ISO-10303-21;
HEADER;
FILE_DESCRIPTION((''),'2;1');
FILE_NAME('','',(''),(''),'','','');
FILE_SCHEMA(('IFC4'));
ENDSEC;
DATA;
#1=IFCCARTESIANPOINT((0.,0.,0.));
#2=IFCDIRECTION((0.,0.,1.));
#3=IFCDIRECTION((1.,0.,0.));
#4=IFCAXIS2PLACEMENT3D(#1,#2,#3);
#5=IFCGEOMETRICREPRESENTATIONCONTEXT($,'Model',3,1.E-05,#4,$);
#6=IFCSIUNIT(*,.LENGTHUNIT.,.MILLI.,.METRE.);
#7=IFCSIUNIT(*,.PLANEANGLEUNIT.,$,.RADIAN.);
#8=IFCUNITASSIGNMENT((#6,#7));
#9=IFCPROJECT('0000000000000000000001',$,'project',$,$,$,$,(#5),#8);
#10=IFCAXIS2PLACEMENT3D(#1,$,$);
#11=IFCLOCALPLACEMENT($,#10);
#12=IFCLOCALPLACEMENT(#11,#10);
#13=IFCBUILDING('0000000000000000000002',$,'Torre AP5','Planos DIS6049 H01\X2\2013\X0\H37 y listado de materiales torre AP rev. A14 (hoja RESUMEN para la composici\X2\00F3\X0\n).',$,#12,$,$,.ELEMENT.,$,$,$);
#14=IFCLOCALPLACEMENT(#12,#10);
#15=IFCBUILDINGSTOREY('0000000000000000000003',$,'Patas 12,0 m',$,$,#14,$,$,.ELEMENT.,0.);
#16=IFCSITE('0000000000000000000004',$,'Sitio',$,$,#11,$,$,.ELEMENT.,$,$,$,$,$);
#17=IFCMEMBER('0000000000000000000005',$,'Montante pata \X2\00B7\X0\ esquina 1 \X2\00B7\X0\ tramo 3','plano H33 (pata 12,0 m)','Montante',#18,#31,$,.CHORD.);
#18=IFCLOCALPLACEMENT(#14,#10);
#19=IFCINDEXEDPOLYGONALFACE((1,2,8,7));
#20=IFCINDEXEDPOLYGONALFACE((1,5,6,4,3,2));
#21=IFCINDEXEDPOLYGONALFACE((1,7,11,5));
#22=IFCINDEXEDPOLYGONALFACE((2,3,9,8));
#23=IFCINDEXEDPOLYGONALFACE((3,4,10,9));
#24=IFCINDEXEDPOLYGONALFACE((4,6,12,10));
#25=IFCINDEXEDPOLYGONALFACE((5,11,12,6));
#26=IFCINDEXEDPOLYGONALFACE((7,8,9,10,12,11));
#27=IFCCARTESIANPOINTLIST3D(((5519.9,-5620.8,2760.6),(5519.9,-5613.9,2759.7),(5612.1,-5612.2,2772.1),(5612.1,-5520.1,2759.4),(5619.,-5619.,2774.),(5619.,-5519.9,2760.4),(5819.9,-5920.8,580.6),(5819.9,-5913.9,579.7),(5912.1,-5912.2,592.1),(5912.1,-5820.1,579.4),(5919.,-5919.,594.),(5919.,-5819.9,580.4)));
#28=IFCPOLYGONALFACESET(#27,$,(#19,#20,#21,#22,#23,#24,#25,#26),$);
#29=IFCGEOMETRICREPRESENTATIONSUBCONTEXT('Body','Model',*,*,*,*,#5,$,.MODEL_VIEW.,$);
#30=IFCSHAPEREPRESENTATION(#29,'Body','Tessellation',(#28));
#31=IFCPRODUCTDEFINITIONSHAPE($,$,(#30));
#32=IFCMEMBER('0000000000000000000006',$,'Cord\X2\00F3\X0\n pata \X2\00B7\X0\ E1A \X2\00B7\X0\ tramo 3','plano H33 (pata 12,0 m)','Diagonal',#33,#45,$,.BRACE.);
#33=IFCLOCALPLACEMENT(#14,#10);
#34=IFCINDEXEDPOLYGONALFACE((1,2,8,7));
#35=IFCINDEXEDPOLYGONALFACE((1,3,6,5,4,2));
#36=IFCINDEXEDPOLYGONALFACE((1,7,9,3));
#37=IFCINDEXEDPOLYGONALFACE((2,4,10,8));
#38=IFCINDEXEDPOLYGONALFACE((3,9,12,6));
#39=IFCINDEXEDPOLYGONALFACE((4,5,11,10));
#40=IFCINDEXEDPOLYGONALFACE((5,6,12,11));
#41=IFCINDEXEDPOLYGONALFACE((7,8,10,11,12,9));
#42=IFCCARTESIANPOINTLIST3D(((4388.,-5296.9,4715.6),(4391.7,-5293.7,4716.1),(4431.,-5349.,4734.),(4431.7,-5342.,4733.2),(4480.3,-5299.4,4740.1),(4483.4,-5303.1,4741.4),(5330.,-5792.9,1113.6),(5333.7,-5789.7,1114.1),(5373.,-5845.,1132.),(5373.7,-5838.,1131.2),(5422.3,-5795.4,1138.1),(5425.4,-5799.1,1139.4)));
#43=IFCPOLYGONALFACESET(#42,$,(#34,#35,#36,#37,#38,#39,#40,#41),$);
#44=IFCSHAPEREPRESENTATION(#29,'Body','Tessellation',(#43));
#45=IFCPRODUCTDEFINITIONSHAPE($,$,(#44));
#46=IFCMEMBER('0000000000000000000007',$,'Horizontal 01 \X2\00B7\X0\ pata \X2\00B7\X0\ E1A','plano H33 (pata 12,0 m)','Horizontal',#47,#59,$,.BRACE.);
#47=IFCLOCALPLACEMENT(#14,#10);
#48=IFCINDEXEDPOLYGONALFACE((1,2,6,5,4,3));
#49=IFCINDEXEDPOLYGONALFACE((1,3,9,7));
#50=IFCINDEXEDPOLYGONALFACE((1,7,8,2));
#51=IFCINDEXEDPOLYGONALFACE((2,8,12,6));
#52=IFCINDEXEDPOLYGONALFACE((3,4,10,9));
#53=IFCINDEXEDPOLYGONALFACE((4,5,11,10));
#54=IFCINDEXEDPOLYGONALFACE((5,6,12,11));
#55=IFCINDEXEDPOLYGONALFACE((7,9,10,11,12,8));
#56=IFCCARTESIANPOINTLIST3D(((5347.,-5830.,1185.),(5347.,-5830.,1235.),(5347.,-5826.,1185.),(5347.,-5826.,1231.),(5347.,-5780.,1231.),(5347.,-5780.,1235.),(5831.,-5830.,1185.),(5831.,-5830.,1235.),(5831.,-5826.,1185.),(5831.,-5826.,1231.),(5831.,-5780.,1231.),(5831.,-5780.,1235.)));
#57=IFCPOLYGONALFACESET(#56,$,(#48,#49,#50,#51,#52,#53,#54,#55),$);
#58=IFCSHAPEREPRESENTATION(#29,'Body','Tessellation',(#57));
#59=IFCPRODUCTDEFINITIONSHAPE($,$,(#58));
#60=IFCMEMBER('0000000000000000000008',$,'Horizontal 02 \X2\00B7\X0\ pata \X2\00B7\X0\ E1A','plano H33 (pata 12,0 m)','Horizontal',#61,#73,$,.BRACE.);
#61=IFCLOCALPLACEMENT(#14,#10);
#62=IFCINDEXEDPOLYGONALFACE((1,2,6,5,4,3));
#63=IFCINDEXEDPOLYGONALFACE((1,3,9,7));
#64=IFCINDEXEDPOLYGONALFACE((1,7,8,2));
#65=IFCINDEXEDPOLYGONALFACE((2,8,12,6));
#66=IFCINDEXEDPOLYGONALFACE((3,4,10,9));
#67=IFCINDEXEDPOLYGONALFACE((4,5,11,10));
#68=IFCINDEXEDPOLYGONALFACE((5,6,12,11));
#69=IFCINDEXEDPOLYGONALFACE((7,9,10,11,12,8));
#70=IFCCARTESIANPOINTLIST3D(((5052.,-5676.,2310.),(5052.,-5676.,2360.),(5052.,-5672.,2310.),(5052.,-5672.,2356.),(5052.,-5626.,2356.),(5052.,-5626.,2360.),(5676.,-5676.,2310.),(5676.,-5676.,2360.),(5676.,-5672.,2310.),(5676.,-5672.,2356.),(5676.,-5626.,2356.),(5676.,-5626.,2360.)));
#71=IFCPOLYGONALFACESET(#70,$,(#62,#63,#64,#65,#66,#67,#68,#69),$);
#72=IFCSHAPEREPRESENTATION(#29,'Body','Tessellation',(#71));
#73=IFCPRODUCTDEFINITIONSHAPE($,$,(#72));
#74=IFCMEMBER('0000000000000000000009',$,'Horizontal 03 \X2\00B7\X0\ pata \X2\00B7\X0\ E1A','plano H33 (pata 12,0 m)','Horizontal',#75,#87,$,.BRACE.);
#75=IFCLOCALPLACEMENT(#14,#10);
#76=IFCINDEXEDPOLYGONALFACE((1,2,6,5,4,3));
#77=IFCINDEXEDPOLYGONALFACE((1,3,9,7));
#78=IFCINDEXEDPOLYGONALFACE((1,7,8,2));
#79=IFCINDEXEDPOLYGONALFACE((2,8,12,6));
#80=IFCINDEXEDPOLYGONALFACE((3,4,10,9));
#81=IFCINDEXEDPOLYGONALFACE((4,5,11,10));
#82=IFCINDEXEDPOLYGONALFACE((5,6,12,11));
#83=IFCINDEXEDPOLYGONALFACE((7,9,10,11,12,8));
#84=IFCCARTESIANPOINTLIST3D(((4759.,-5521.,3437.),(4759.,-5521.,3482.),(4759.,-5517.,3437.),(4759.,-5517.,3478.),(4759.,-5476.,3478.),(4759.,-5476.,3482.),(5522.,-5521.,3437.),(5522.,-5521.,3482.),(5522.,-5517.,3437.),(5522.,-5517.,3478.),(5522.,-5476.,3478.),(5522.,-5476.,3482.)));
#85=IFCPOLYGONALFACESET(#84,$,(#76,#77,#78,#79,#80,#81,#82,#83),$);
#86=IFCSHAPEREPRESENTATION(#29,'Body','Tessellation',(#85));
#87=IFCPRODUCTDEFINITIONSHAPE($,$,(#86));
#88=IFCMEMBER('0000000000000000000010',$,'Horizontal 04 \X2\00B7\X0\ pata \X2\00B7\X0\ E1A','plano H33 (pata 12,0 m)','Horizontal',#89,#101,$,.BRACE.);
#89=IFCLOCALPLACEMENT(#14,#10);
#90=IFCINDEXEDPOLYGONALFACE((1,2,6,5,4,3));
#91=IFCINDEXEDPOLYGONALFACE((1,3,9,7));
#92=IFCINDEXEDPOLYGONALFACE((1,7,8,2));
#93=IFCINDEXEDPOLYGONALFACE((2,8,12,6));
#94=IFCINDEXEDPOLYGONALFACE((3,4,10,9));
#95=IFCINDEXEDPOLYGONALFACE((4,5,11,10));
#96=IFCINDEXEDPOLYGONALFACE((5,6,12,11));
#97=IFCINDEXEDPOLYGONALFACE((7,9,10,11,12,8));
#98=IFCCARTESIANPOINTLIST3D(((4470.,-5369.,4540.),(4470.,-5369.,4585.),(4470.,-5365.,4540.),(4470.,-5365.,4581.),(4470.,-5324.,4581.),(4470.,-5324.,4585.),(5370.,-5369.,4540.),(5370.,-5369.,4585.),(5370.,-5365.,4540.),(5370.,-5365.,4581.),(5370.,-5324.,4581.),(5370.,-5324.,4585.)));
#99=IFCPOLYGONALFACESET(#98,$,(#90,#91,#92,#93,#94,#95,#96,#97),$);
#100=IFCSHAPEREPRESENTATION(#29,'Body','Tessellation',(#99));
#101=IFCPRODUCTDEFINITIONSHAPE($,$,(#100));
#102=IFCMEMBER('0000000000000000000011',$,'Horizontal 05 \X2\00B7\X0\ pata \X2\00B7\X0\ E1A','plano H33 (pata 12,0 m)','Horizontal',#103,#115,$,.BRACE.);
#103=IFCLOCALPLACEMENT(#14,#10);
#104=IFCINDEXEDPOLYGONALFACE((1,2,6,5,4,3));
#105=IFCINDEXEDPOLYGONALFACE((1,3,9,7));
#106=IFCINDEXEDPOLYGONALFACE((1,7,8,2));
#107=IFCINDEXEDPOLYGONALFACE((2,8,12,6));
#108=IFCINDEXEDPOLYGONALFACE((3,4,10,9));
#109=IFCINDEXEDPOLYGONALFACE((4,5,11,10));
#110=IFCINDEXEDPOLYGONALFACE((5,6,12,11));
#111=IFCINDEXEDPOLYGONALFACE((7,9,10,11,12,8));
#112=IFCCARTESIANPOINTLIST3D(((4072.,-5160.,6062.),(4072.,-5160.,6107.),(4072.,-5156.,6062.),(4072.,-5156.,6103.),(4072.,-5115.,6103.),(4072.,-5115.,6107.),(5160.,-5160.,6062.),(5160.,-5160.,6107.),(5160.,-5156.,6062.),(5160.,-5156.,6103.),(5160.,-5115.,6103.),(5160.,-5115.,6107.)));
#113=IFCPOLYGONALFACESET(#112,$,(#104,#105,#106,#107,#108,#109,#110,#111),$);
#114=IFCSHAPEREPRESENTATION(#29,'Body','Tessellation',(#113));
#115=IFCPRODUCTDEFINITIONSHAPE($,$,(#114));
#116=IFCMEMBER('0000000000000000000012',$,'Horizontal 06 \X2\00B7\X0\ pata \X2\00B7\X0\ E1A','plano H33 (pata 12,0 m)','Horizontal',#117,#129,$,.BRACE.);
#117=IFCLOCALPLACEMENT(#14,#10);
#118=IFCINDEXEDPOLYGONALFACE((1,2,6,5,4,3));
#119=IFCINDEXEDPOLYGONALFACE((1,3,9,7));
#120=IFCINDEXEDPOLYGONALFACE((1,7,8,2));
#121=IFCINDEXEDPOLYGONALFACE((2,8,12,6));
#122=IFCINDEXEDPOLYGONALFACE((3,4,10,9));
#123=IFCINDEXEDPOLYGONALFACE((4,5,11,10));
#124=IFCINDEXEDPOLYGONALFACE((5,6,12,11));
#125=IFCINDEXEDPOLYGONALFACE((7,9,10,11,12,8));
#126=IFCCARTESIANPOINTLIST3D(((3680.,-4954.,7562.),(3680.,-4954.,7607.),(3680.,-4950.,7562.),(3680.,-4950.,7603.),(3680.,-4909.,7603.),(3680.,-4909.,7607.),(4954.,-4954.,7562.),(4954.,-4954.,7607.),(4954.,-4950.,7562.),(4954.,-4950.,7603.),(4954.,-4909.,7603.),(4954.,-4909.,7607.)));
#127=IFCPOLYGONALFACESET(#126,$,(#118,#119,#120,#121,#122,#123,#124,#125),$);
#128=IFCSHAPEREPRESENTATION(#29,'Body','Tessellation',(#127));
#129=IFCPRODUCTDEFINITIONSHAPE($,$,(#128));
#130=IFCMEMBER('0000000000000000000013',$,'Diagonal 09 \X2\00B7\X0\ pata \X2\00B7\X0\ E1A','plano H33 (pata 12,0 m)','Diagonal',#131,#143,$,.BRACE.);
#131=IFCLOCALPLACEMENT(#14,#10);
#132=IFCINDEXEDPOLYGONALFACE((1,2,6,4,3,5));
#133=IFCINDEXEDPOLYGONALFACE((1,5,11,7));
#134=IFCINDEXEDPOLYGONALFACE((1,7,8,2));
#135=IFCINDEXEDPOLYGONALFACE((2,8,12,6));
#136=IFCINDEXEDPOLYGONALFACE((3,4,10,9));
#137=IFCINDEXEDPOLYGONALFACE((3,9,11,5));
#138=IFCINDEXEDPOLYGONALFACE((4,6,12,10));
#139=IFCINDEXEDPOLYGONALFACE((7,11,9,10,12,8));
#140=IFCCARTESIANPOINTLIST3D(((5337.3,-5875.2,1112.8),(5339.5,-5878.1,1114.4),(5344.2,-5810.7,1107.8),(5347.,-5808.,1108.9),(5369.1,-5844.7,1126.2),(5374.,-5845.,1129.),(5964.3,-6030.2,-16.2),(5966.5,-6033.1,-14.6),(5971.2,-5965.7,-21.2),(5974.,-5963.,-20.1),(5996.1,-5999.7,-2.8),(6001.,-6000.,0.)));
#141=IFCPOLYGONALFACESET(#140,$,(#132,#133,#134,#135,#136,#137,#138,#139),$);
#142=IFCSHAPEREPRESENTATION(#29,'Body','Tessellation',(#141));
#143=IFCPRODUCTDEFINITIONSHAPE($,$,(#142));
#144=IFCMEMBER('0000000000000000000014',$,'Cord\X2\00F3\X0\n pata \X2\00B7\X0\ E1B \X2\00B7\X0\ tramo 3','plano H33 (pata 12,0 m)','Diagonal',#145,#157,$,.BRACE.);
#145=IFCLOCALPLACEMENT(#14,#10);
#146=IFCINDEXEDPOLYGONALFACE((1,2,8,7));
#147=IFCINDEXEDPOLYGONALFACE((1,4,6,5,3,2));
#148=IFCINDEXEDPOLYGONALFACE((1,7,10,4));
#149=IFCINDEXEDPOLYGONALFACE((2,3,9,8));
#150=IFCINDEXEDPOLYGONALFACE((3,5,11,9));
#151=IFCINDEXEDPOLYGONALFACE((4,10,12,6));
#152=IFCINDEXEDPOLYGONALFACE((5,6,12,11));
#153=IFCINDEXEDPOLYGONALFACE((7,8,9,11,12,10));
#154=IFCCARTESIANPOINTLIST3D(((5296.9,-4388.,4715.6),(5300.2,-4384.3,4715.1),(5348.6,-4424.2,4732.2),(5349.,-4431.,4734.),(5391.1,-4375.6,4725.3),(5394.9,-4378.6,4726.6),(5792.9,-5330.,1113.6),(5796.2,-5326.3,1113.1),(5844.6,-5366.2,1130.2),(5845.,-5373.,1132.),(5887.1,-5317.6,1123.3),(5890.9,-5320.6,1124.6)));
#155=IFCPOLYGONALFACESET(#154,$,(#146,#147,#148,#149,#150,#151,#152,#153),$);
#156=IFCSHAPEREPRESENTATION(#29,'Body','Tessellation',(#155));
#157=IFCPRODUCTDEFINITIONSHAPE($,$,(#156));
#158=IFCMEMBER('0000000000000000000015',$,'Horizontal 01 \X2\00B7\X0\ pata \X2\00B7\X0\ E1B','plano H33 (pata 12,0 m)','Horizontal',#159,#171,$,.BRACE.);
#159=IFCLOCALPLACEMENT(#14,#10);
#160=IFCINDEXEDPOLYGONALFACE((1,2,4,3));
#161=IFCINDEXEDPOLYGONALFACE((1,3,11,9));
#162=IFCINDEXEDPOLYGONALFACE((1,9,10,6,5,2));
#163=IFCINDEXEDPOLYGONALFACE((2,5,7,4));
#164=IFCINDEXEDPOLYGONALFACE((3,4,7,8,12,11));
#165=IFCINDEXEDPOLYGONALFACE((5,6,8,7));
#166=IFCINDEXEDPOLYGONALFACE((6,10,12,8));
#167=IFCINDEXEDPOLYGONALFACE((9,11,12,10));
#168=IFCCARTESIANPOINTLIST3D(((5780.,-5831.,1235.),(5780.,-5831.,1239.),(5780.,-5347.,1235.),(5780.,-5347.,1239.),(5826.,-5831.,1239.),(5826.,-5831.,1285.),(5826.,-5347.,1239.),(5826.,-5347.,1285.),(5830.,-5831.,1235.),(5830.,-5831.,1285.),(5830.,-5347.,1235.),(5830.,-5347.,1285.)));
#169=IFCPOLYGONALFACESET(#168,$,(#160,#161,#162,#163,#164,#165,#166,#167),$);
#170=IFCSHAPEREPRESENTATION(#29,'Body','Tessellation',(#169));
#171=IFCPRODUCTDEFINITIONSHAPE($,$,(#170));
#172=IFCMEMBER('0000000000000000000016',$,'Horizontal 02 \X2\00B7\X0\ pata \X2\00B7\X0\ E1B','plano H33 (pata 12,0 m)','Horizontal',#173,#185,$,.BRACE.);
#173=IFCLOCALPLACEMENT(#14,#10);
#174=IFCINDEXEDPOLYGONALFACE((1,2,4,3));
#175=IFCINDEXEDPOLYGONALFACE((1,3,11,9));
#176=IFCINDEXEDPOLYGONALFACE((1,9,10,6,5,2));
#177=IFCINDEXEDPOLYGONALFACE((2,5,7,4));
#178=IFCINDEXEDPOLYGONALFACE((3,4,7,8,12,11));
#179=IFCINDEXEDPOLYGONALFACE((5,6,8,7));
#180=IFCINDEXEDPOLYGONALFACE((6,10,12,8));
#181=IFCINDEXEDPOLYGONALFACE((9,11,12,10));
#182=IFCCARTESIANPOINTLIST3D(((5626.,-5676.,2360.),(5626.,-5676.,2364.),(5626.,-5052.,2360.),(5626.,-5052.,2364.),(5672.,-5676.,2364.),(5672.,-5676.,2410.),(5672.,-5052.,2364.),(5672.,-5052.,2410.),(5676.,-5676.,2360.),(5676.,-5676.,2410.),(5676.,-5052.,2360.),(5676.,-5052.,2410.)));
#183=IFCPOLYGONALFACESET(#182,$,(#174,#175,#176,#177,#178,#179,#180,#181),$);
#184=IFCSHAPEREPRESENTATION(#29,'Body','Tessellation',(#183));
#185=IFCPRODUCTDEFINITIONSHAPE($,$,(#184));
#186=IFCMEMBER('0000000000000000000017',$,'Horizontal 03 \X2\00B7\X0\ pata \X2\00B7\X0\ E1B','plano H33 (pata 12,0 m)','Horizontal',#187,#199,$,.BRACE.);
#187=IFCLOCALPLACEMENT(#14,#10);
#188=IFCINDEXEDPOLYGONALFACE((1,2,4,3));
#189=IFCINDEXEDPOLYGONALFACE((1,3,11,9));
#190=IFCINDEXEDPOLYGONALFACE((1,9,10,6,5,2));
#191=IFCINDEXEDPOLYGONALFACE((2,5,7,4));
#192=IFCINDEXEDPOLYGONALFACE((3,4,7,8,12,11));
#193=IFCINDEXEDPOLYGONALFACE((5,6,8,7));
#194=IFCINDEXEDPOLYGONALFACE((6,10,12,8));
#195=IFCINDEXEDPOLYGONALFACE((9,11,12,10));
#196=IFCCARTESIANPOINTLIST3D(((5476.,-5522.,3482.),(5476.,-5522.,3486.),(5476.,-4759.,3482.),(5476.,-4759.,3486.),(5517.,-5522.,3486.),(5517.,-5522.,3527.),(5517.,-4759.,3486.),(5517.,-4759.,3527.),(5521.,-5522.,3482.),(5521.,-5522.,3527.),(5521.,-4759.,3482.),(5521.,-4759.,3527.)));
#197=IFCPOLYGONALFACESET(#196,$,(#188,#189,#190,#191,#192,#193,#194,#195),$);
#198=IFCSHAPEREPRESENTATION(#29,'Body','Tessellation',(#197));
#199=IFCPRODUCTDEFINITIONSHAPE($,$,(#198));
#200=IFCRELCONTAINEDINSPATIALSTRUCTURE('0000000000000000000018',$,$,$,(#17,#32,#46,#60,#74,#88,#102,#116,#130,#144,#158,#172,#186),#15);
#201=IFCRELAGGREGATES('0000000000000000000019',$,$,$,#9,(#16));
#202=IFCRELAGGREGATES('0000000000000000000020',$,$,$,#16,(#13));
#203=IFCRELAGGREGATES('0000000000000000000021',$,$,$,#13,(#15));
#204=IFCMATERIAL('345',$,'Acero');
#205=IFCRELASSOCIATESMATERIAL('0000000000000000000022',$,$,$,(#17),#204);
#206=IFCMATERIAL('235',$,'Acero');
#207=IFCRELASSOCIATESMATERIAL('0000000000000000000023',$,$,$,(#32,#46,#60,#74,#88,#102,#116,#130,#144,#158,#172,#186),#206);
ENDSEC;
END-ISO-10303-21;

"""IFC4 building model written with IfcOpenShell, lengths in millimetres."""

from ifc_helpers import new_model, si_unit, frame, frame_2d, origin, origin_with_axes, place, context, subcontext, project, spatial, l_section, extrude, material, element, save


model = new_model("IFC4")

# Units and contexts
model_context = context("Model", 3, precision=1e-05, world=origin_with_axes())
body_context = subcontext(model_context, "Body", "Model", "MODEL_VIEW")
ifc_project = project(units=[si_unit("LENGTHUNIT", "METRE", prefix="MILLI"), si_unit("PLANEANGLEUNIT", "RADIAN")], contexts=[model_context])

# Site, building, storey
site_placement = place(None, origin())
site = spatial("IfcSite", under=ifc_project, at=site_placement, Name="Sitio", CompositionType="ELEMENT")
building_placement = place(site_placement, origin())
building = spatial("IfcBuilding", under=site, at=building_placement, Name="Torre AP5", Description="Planos DIS6049 H01–H37 y listado de materiales torre AP rev. A14 (hoja RESUMEN para la composición).", CompositionType="ELEMENT")
storey_placement = place(building_placement, origin())
storey = spatial("IfcBuildingStorey", under=building, at=storey_placement, Name="Patas 12,0 m", CompositionType="ELEMENT", Elevation=0.0)

# Members
ifc_material_1 = material(Name="345", Category="Acero")
member_1_placement = place(storey_placement, frame((5619.0, -5619.0, 2774.0), z_axis=(0.13508, -0.13508, -0.981584), x_axis=(-0.990835, -0.018415, -0.133819)))
element("IfcMember", 1, at=member_1_placement, inside=storey, material=ifc_material_1, Name="Montante pata · esquina 1 · tramo 3", Description="plano H33 (pata 12,0 m)", ObjectType="Montante", PredefinedType="CHORD", context=body_context, shape_type="SweptSolid", body=[
    extrude(l_section(Depth=100.0, Width=100.0, Thickness=7.0, at=frame_2d((50.0, 50.0))), None, (0.0, 0.0, 1.0), 2220.9),
])
ifc_material_2 = material(Name="235", Category="Acero")
member_2_placement = place(storey_placement, frame((4431.0, -5349.0, 4734.0), z_axis=(0.250797, -0.132054, -0.958991), x_axis=(-0.614396, 0.743837, -0.263105)))
element("IfcMember", 2, at=member_2_placement, inside=storey, material=ifc_material_2, Name="Cordón pata · E1A · tramo 3", Description="plano H33 (pata 12,0 m)", ObjectType="Diagonal", PredefinedType="BRACE", context=body_context, shape_type="SweptSolid", body=[
    extrude(l_section(Depth=70.0, Width=70.0, Thickness=5.0, at=frame_2d((35.0, 35.0))), None, (0.0, 0.0, 1.0), 3756.0),
])
member_3_placement = place(storey_placement, frame((5831.0, -5830.0, 1235.0), z_axis=(-1.0, 0.0, 0.0), x_axis=(0.0, 1.0, 0.0)))
element("IfcMember", 3, at=member_3_placement, inside=storey, material=ifc_material_2, Name="Horizontal 01 · pata · E1A", Description="plano H33 (pata 12,0 m)", ObjectType="Horizontal", PredefinedType="BRACE", context=body_context, shape_type="SweptSolid", body=[
    extrude(l_section(Depth=50.0, Width=50.0, Thickness=4.0, at=frame_2d((25.0, 25.0))), None, (0.0, 0.0, 1.0), 484.0),
])
member_4_placement = place(storey_placement, frame((5676.0, -5676.0, 2360.0), z_axis=(-1.0, 0.0, 0.0), x_axis=(0.0, 1.0, 0.0)))
element("IfcMember", 4, at=member_4_placement, inside=storey, material=ifc_material_2, Name="Horizontal 02 · pata · E1A", Description="plano H33 (pata 12,0 m)", ObjectType="Horizontal", PredefinedType="BRACE", context=body_context, shape_type="SweptSolid", body=[
    extrude(l_section(Depth=50.0, Width=50.0, Thickness=4.0, at=frame_2d((25.0, 25.0))), None, (0.0, 0.0, 1.0), 624.0),
])
member_5_placement = place(storey_placement, frame((5522.0, -5521.0, 3482.0), z_axis=(-1.0, 0.0, 0.0), x_axis=(0.0, 1.0, 0.0)))
element("IfcMember", 5, at=member_5_placement, inside=storey, material=ifc_material_2, Name="Horizontal 03 · pata · E1A", Description="plano H33 (pata 12,0 m)", ObjectType="Horizontal", PredefinedType="BRACE", context=body_context, shape_type="SweptSolid", body=[
    extrude(l_section(Depth=45.0, Width=45.0, Thickness=4.0, at=frame_2d((22.5, 22.5))), None, (0.0, 0.0, 1.0), 763.0),
])
member_6_placement = place(storey_placement, frame((5370.0, -5369.0, 4585.0), z_axis=(-1.0, 0.0, 0.0), x_axis=(0.0, 1.0, 0.0)))
element("IfcMember", 6, at=member_6_placement, inside=storey, material=ifc_material_2, Name="Horizontal 04 · pata · E1A", Description="plano H33 (pata 12,0 m)", ObjectType="Horizontal", PredefinedType="BRACE", context=body_context, shape_type="SweptSolid", body=[
    extrude(l_section(Depth=45.0, Width=45.0, Thickness=4.0, at=frame_2d((22.5, 22.5))), None, (0.0, 0.0, 1.0), 900.0),
])
member_7_placement = place(storey_placement, frame((5160.0, -5160.0, 6107.0), z_axis=(-1.0, 0.0, 0.0), x_axis=(0.0, 1.0, 0.0)))
element("IfcMember", 7, at=member_7_placement, inside=storey, material=ifc_material_2, Name="Horizontal 05 · pata · E1A", Description="plano H33 (pata 12,0 m)", ObjectType="Horizontal", PredefinedType="BRACE", context=body_context, shape_type="SweptSolid", body=[
    extrude(l_section(Depth=45.0, Width=45.0, Thickness=4.0, at=frame_2d((22.5, 22.5))), None, (0.0, 0.0, 1.0), 1088.0),
])
member_8_placement = place(storey_placement, frame((4954.0, -4954.0, 7607.0), z_axis=(-1.0, 0.0, 0.0), x_axis=(0.0, 1.0, 0.0)))
element("IfcMember", 8, at=member_8_placement, inside=storey, material=ifc_material_2, Name="Horizontal 06 · pata · E1A", Description="plano H33 (pata 12,0 m)", ObjectType="Horizontal", PredefinedType="BRACE", context=body_context, shape_type="SweptSolid", body=[
    extrude(l_section(Depth=45.0, Width=45.0, Thickness=4.0, at=frame_2d((22.5, 22.5))), None, (0.0, 0.0, 1.0), 1274.0),
])
member_9_placement = place(storey_placement, frame((6001.0, -6000.0, 0.0), z_axis=(-0.482052, 0.119168, 0.868001), x_axis=(-0.54018, 0.73958, -0.40153)))
element("IfcMember", 9, at=member_9_placement, inside=storey, material=ifc_material_2, Name="Diagonal 09 · pata · E1A", Description="plano H33 (pata 12,0 m)", ObjectType="Diagonal", PredefinedType="BRACE", context=body_context, shape_type="SweptSolid", body=[
    extrude(l_section(Depth=50.0, Width=50.0, Thickness=4.0, at=frame_2d((25.0, 25.0))), None, (0.0, 0.0, 1.0), 1300.7),
])
member_10_placement = place(storey_placement, frame((5349.0, -4431.0, 4734.0), z_axis=(0.132054, -0.250797, -0.958991), x_axis=(-0.743837, 0.614396, -0.263105)))
element("IfcMember", 10, at=member_10_placement, inside=storey, material=ifc_material_2, Name="Cordón pata · E1B · tramo 3", Description="plano H33 (pata 12,0 m)", ObjectType="Diagonal", PredefinedType="BRACE", context=body_context, shape_type="SweptSolid", body=[
    extrude(l_section(Depth=70.0, Width=70.0, Thickness=5.0, at=frame_2d((35.0, 35.0))), None, (0.0, 0.0, 1.0), 3756.0),
])
member_11_placement = place(storey_placement, frame((5830.0, -5831.0, 1235.0), z_axis=(0.0, 1.0, 0.0), x_axis=(-1.0, 0.0, 0.0)))
element("IfcMember", 11, at=member_11_placement, inside=storey, material=ifc_material_2, Name="Horizontal 01 · pata · E1B", Description="plano H33 (pata 12,0 m)", ObjectType="Horizontal", PredefinedType="BRACE", context=body_context, shape_type="SweptSolid", body=[
    extrude(l_section(Depth=50.0, Width=50.0, Thickness=4.0, at=frame_2d((25.0, 25.0))), None, (0.0, 0.0, 1.0), 484.0),
])
member_12_placement = place(storey_placement, frame((5676.0, -5676.0, 2360.0), z_axis=(0.0, 1.0, 0.0), x_axis=(-1.0, 0.0, 0.0)))
element("IfcMember", 12, at=member_12_placement, inside=storey, material=ifc_material_2, Name="Horizontal 02 · pata · E1B", Description="plano H33 (pata 12,0 m)", ObjectType="Horizontal", PredefinedType="BRACE", context=body_context, shape_type="SweptSolid", body=[
    extrude(l_section(Depth=50.0, Width=50.0, Thickness=4.0, at=frame_2d((25.0, 25.0))), None, (0.0, 0.0, 1.0), 624.0),
])
member_13_placement = place(storey_placement, frame((5521.0, -5522.0, 3482.0), z_axis=(0.0, 1.0, 0.0), x_axis=(-1.0, 0.0, 0.0)))
element("IfcMember", 13, at=member_13_placement, inside=storey, material=ifc_material_2, Name="Horizontal 03 · pata · E1B", Description="plano H33 (pata 12,0 m)", ObjectType="Horizontal", PredefinedType="BRACE", context=body_context, shape_type="SweptSolid", body=[
    extrude(l_section(Depth=45.0, Width=45.0, Thickness=4.0, at=frame_2d((22.5, 22.5))), None, (0.0, 0.0, 1.0), 763.0),
])

save(model, "model.ifc")
